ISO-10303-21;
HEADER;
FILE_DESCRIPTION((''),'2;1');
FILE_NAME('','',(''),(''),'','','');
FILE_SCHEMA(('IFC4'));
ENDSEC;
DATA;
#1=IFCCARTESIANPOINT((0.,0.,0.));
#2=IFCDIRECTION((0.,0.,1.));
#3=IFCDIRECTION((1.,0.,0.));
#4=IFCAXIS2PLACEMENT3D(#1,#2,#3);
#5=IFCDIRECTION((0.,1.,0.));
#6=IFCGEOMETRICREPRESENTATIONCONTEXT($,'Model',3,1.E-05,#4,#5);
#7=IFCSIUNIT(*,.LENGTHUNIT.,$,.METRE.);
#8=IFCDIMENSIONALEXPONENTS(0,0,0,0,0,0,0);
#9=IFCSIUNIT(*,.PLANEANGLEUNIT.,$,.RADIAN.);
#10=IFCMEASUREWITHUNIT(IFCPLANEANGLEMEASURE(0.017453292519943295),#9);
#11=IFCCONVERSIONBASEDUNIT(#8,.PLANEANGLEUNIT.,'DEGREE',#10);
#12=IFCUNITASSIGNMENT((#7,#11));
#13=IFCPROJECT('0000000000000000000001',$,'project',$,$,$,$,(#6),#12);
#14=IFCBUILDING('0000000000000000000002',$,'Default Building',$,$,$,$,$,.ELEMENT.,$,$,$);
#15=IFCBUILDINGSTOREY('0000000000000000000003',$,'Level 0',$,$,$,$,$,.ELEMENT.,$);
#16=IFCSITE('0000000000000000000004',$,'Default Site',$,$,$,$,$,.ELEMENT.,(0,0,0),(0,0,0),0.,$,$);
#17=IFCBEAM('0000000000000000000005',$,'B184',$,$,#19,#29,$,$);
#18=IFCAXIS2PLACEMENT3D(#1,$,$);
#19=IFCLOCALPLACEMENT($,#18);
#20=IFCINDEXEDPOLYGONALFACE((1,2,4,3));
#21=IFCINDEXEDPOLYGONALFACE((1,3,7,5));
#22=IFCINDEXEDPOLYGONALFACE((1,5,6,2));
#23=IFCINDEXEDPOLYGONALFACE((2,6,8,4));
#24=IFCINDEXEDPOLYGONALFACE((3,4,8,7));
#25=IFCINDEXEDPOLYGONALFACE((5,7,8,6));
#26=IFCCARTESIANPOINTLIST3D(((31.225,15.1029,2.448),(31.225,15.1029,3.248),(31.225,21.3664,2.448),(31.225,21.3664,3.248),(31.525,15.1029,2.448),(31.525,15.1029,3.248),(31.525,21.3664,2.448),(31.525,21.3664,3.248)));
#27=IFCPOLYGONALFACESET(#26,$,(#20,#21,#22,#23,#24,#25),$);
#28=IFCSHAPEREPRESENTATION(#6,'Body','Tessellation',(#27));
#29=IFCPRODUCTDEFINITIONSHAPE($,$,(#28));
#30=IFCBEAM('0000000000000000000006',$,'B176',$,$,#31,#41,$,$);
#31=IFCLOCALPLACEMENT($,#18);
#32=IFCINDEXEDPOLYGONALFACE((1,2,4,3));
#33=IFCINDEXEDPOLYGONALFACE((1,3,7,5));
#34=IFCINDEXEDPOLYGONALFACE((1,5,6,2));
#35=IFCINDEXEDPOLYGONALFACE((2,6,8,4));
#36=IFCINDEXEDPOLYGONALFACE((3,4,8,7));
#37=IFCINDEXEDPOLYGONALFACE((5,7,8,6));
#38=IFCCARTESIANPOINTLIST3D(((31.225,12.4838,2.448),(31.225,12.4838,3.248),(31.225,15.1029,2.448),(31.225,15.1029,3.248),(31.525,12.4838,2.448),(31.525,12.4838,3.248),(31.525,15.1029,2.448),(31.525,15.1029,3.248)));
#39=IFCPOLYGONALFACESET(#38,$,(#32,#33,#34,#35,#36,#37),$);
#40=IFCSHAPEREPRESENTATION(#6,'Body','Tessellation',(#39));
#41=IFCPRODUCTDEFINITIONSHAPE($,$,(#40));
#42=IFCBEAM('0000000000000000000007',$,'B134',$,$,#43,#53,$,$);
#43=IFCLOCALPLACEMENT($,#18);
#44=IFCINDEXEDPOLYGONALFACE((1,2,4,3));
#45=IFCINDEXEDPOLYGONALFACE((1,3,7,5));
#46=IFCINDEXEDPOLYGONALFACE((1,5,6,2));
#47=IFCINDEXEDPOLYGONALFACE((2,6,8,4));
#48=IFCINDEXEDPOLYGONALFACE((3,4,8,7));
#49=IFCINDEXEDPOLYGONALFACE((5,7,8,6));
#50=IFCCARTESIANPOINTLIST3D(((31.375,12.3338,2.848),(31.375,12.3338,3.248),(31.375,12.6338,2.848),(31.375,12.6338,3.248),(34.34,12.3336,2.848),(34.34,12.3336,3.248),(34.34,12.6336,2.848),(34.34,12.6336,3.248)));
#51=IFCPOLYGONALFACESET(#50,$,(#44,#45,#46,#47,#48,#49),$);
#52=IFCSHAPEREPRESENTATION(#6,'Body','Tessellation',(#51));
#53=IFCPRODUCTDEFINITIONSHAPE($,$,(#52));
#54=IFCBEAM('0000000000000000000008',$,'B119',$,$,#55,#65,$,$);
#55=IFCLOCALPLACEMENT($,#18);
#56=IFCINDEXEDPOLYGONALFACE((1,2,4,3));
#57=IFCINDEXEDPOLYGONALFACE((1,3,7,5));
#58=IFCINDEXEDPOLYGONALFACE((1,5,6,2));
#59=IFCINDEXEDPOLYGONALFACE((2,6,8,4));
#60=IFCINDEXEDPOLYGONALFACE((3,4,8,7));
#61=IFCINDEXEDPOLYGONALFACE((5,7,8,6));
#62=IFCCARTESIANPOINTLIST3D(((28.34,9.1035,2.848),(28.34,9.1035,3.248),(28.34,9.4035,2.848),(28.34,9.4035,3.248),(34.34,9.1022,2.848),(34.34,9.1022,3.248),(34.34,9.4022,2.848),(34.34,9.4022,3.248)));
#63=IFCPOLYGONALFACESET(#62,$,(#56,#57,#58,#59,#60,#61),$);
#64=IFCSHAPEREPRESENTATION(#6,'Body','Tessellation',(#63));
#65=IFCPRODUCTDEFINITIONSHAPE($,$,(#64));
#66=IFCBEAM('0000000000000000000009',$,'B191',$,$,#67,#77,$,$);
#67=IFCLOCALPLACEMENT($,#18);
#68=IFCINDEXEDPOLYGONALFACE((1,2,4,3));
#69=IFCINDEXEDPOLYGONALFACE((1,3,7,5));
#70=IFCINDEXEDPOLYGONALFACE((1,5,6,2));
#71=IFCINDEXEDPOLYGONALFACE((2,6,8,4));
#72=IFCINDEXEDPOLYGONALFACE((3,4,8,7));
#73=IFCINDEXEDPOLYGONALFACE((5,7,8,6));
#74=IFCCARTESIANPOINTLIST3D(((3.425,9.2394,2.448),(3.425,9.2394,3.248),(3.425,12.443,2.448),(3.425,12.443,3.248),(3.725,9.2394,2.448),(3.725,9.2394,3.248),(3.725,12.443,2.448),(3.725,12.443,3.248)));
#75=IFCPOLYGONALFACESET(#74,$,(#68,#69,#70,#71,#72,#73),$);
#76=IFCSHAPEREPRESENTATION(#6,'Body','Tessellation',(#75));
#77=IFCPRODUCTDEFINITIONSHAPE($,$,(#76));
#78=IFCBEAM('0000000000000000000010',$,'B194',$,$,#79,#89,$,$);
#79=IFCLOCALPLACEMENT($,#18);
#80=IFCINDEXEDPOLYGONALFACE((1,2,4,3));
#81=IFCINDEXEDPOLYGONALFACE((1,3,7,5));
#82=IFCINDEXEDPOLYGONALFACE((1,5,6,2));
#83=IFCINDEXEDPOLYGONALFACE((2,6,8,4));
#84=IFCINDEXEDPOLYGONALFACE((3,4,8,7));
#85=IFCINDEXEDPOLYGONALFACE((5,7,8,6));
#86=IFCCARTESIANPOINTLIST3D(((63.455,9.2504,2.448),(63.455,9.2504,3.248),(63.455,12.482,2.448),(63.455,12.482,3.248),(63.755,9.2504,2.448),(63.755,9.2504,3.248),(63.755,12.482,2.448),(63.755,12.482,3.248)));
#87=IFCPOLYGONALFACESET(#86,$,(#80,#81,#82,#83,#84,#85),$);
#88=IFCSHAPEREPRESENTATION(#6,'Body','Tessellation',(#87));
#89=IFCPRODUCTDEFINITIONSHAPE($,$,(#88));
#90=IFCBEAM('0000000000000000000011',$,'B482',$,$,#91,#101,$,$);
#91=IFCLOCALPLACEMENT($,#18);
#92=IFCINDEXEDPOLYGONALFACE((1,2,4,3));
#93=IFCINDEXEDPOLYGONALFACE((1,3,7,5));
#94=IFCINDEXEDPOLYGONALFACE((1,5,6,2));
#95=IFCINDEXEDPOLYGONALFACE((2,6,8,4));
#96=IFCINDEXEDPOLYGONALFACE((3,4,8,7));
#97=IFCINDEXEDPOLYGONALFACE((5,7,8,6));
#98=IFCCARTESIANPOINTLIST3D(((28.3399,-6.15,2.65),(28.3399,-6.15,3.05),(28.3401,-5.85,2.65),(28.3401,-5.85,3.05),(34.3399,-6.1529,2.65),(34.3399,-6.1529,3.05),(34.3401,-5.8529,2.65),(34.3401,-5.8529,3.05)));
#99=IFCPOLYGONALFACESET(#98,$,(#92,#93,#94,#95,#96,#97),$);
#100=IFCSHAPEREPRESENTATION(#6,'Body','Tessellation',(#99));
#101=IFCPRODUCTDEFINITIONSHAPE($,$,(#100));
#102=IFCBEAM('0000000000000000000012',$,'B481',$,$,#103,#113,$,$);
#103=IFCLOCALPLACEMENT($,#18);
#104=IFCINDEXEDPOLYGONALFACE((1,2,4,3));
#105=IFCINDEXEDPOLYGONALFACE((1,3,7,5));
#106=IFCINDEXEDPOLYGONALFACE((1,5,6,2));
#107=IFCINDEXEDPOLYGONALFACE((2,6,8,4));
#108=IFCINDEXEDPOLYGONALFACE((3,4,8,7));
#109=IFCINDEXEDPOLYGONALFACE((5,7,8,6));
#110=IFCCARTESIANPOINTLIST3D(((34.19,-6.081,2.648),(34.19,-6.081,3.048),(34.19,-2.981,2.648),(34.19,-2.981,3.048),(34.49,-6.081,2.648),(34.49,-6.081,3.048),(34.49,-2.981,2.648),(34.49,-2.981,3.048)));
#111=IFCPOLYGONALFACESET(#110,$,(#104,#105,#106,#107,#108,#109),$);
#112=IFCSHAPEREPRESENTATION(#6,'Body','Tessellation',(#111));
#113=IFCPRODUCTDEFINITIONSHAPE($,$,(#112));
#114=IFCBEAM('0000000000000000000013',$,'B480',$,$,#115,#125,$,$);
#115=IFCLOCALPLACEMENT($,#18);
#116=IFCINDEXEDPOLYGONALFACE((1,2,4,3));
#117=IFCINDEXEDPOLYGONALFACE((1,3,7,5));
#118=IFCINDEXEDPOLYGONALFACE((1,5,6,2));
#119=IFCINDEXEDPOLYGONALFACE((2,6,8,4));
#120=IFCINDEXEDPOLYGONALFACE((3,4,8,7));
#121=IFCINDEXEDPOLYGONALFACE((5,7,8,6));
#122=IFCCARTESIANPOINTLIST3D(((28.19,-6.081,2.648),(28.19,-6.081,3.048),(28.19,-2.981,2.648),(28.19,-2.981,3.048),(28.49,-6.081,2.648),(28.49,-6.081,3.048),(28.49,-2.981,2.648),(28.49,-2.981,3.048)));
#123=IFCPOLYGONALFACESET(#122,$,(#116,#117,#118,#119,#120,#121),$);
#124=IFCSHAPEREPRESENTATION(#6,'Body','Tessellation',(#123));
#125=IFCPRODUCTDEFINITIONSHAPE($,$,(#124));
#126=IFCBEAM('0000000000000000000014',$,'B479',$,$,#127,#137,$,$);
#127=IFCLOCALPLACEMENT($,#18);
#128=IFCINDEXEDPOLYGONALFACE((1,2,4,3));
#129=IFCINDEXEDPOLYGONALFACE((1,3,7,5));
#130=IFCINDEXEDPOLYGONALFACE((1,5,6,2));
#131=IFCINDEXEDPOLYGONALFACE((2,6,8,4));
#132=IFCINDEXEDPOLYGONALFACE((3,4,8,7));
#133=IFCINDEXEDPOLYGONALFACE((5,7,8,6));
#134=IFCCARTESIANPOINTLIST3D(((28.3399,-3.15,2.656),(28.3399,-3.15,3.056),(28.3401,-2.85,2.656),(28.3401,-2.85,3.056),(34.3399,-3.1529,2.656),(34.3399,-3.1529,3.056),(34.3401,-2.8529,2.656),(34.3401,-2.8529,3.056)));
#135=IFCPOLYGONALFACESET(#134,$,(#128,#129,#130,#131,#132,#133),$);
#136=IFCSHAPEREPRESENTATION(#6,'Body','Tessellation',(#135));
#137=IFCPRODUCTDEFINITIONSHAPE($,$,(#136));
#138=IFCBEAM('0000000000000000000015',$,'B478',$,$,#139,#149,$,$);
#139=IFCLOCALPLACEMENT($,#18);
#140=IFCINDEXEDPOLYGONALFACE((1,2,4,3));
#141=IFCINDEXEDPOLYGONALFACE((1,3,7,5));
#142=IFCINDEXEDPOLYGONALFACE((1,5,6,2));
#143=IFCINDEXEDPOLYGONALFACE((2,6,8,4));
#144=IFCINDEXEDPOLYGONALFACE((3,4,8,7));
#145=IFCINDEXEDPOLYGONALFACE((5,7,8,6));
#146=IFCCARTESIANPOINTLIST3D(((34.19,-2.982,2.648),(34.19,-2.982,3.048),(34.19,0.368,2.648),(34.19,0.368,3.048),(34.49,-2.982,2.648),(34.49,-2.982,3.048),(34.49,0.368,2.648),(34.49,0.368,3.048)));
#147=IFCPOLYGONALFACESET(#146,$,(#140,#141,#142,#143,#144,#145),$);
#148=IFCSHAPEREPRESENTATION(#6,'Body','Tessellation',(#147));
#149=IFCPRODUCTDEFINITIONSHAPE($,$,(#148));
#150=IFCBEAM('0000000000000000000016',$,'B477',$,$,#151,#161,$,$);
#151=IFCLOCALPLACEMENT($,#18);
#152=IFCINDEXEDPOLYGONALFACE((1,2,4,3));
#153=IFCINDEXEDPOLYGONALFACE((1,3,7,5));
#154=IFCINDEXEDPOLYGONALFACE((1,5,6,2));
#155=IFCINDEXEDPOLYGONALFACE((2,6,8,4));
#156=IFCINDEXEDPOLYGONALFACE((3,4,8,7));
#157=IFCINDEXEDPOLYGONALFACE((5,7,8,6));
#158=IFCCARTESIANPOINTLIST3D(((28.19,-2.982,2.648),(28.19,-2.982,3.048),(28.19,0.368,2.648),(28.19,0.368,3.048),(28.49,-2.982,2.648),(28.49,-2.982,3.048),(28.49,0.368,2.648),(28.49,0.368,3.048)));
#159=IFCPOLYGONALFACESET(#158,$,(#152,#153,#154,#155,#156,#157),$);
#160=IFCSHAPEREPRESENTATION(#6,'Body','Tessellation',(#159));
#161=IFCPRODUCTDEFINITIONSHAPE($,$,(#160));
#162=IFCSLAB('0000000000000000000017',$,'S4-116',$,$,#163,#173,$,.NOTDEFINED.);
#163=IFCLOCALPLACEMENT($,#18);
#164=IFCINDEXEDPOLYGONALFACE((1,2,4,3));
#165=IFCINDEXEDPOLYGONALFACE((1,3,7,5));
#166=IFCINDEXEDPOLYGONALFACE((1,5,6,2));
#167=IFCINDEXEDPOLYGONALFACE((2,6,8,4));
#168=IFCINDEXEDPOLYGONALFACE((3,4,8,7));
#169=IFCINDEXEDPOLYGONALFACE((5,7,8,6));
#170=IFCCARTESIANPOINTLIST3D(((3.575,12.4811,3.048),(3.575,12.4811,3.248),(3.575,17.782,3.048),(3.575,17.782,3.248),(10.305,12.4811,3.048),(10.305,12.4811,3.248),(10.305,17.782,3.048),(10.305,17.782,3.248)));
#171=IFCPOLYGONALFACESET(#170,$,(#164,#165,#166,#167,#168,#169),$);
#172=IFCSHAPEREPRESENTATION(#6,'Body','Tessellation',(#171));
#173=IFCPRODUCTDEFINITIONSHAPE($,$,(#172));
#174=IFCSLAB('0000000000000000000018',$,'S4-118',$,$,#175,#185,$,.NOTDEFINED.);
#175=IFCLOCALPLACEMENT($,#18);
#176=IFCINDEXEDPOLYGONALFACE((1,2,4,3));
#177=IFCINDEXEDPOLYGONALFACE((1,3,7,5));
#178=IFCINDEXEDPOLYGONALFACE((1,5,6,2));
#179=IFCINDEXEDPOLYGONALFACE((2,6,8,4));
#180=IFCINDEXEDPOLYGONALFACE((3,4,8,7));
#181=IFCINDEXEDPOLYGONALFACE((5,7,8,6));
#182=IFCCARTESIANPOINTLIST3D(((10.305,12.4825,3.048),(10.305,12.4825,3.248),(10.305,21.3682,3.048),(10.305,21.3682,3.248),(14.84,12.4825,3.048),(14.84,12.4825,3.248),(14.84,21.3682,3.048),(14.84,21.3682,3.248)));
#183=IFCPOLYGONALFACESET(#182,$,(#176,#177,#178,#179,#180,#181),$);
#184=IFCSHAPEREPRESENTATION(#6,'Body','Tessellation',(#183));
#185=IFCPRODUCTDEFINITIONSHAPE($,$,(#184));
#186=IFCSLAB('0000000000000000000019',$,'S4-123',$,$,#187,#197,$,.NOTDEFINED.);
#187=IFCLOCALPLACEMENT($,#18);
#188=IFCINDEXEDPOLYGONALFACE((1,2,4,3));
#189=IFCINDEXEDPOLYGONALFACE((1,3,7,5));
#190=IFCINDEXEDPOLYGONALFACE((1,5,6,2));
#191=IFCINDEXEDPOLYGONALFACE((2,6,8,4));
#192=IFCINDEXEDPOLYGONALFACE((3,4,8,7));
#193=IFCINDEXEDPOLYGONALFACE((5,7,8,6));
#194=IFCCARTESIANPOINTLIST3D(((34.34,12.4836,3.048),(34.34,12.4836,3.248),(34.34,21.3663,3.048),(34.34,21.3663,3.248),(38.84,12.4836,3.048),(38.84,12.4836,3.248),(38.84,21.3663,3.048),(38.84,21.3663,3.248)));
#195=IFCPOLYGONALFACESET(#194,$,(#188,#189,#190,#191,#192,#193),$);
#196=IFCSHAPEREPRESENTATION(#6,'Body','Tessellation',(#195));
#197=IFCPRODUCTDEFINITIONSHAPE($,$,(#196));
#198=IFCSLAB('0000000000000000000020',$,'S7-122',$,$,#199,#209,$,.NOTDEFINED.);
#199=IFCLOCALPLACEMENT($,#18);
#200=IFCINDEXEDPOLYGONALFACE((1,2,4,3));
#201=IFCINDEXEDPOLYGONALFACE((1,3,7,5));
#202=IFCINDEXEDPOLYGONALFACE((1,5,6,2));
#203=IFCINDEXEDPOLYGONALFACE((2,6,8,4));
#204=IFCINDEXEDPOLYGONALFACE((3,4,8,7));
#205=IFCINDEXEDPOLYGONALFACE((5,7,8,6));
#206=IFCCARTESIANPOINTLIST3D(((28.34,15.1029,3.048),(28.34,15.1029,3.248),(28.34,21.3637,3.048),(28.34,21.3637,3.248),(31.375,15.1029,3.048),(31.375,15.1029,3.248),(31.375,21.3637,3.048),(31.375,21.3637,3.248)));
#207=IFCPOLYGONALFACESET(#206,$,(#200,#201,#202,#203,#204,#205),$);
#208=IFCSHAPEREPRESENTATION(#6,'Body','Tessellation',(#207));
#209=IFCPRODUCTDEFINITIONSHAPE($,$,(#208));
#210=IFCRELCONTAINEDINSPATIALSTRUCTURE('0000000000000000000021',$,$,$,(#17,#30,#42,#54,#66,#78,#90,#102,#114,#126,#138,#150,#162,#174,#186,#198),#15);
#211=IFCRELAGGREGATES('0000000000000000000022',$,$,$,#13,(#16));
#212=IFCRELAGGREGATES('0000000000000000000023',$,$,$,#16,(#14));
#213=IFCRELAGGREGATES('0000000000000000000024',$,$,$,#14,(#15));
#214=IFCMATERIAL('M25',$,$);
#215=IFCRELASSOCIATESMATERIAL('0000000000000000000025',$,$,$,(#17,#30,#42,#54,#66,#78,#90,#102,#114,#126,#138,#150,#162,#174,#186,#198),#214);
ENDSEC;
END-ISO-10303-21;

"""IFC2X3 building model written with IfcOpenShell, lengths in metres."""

from ifc_helpers import new_model, entity, si_unit, converted_unit, direction, frame, frame_2d, origin_with_axes, place, context, project, spatial, rectangle, extrude, material, element, save


model = new_model("IFC2X3")

# Units and contexts
model_context = context("Model", 3, precision=1e-05, world=origin_with_axes(), true_north=direction((0.0, 1.0, 0.0)))
ifc_project = project(units=[si_unit("LENGTHUNIT", "METRE"), converted_unit("PLANEANGLEUNIT", "DEGREE", entity("IfcPlaneAngleMeasure", 0.017453292519943295), si_unit("PLANEANGLEUNIT", "RADIAN"), dimensions=[0, 0, 0, 0, 0, 0, 0])], contexts=[model_context])

# Site, building, storey
site = spatial("IfcSite", under=ifc_project, Name="Default Site", CompositionType="ELEMENT", RefLatitude=(0, 0, 0), RefLongitude=(0, 0, 0), RefElevation=0.0)
building = spatial("IfcBuilding", under=site, Name="Default Building", CompositionType="ELEMENT")
storey = spatial("IfcBuildingStorey", under=building, Name="Level 0", CompositionType="ELEMENT")

# Beams
ifc_material = material(Name="M25")
placement = place(None, origin_with_axes())
element("IfcBeam", 1, at=placement, inside=storey, material=ifc_material, Name="B184", context=model_context, shape_type="SweptSolid", body=[
    extrude(rectangle(XDim=0.3, YDim=0.8, at=frame_2d((0.0, 0.0), x_axis=(0.0, 1.0, 0.0))), frame((31.375, 21.3664, 2.848), z_axis=(0.0, -1.0, 0.0), x_axis=(0.0, 0.0, -1.0)), (0.0, 0.0, 1.0), 6.2635),
])
element("IfcBeam", 2, at=placement, inside=storey, material=ifc_material, Name="B176", context=model_context, shape_type="SweptSolid", body=[
    extrude(rectangle(XDim=0.3, YDim=0.8, at=frame_2d((0.0, 0.0), x_axis=(0.0, 1.0, 0.0))), frame((31.375, 15.1029, 2.848), z_axis=(0.0, -1.0, 0.0), x_axis=(0.0, 0.0, -1.0)), (0.0, 0.0, 1.0), 2.6191),
])
element("IfcBeam", 3, at=placement, inside=storey, material=ifc_material, Name="B134", context=model_context, shape_type="SweptSolid", body=[
    extrude(rectangle(XDim=0.3, YDim=0.4, at=frame_2d((0.0, 0.0), x_axis=(0.0, 1.0, 0.0))), frame((31.375, 12.4838, 3.048), z_axis=(1.0, -0.000067, 0.0), x_axis=(0.0, 0.0, -1.0)), (0.0, 0.0, 1.0), 2.965),
])
element("IfcBeam", 4, at=placement, inside=storey, material=ifc_material, Name="B119", context=model_context, shape_type="SweptSolid", body=[
    extrude(rectangle(XDim=0.3, YDim=0.4, at=frame_2d((0.0, 0.0), x_axis=(0.0, 1.0, 0.0))), frame((28.34, 9.2535, 3.048), z_axis=(1.0, -0.000213, 0.0), x_axis=(0.0, 0.0, -1.0)), (0.0, 0.0, 1.0), 6.0),
])
element("IfcBeam", 5, at=placement, inside=storey, material=ifc_material, Name="B191", context=model_context, shape_type="SweptSolid", body=[
    extrude(rectangle(XDim=0.3, YDim=0.8, at=frame_2d((0.0, 0.0), x_axis=(0.0, 1.0, 0.0))), frame((3.575, 12.443, 2.848), z_axis=(0.0, -1.0, 0.0), x_axis=(0.0, 0.0, -1.0)), (0.0, 0.0, 1.0), 3.2036),
])
element("IfcBeam", 6, at=placement, inside=storey, material=ifc_material, Name="B194", context=model_context, shape_type="SweptSolid", body=[
    extrude(rectangle(XDim=0.3, YDim=0.8, at=frame_2d((0.0, 0.0), x_axis=(0.0, 1.0, 0.0))), frame((63.605, 12.482, 2.848), z_axis=(0.0, -1.0, 0.0), x_axis=(0.0, 0.0, -1.0)), (0.0, 0.0, 1.0), 3.2316),
])
element("IfcBeam", 7, at=placement, inside=storey, material=ifc_material, Name="B482", context=model_context, shape_type="SweptSolid", body=[
    extrude(rectangle(XDim=0.3, YDim=0.4, at=frame_2d((0.0, 0.0), x_axis=(0.0, 1.0, 0.0))), frame((28.34, -6.0, 2.85), z_axis=(1.0, -0.000487, 0.0), x_axis=(0.0, 0.0, -1.0)), (0.0, 0.0, 1.0), 6.0),
])
element("IfcBeam", 8, at=placement, inside=storey, material=ifc_material, Name="B481", context=model_context, shape_type="SweptSolid", body=[
    extrude(rectangle(XDim=0.3, YDim=0.4, at=frame_2d((0.0, 0.0), x_axis=(0.0, 1.0, 0.0))), frame((34.34, -6.081, 2.848), z_axis=(0.0, 1.0, 0.0), x_axis=(0.0, 0.0, -1.0)), (0.0, 0.0, 1.0), 3.1),
])
element("IfcBeam", 9, at=placement, inside=storey, material=ifc_material, Name="B480", context=model_context, shape_type="SweptSolid", body=[
    extrude(rectangle(XDim=0.3, YDim=0.4, at=frame_2d((0.0, 0.0), x_axis=(0.0, 1.0, 0.0))), frame((28.34, -6.081, 2.848), z_axis=(0.0, 1.0, 0.0), x_axis=(0.0, 0.0, -1.0)), (0.0, 0.0, 1.0), 3.1),
])
element("IfcBeam", 10, at=placement, inside=storey, material=ifc_material, Name="B479", context=model_context, shape_type="SweptSolid", body=[
    extrude(rectangle(XDim=0.3, YDim=0.4, at=frame_2d((0.0, 0.0), x_axis=(0.0, 1.0, 0.0))), frame((28.34, -3.0, 2.856), z_axis=(1.0, -0.000487, 0.0), x_axis=(0.0, 0.0, -1.0)), (0.0, 0.0, 1.0), 6.0),
])
element("IfcBeam", 11, at=placement, inside=storey, material=ifc_material, Name="B478", context=model_context, shape_type="SweptSolid", body=[
    extrude(rectangle(XDim=0.3, YDim=0.4, at=frame_2d((0.0, 0.0), x_axis=(0.0, 1.0, 0.0))), frame((34.34, -2.982, 2.848), z_axis=(0.0, 1.0, 0.0), x_axis=(0.0, 0.0, -1.0)), (0.0, 0.0, 1.0), 3.35),
])
element("IfcBeam", 12, at=placement, inside=storey, material=ifc_material, Name="B477", context=model_context, shape_type="SweptSolid", body=[
    extrude(rectangle(XDim=0.3, YDim=0.4, at=frame_2d((0.0, 0.0), x_axis=(0.0, 1.0, 0.0))), frame((28.34, -2.982, 2.848), z_axis=(0.0, 1.0, 0.0), x_axis=(0.0, 0.0, -1.0)), (0.0, 0.0, 1.0), 3.35),
])

# Slabs
element("IfcSlab", 13, at=placement, inside=storey, material=ifc_material, Name="S4-116", PredefinedType="NOTDEFINED", context=model_context, shape_type="SweptSolid", body=[
    extrude(rectangle(XDim=6.73, YDim=5.3009, at=frame_2d((0.0, 0.0), x_axis=(1.0, 0.0, 0.0))), frame((6.94, 15.1315, 3.048), z_axis=(0.0, 0.0, 1.0), x_axis=(1.0, 0.0, 0.0)), (0.0, 0.0, 1.0), 0.2),
])
element("IfcSlab", 14, at=placement, inside=storey, material=ifc_material, Name="S4-118", PredefinedType="NOTDEFINED", context=model_context, shape_type="SweptSolid", body=[
    extrude(rectangle(XDim=4.535, YDim=8.8857, at=frame_2d((0.0, 0.0), x_axis=(1.0, 0.0, 0.0))), frame((12.5725, 16.9253, 3.048), z_axis=(0.0, 0.0, 1.0), x_axis=(1.0, 0.0, 0.0)), (0.0, 0.0, 1.0), 0.2),
])
element("IfcSlab", 15, at=placement, inside=storey, material=ifc_material, Name="S4-123", PredefinedType="NOTDEFINED", context=model_context, shape_type="SweptSolid", body=[
    extrude(rectangle(XDim=4.5, YDim=8.8827, at=frame_2d((0.0, 0.0), x_axis=(1.0, 0.0, 0.0))), frame((36.59, 16.925, 3.048), z_axis=(0.0, 0.0, 1.0), x_axis=(1.0, 0.0, 0.0)), (0.0, 0.0, 1.0), 0.2),
])
element("IfcSlab", 16, at=placement, inside=storey, material=ifc_material, Name="S7-122", PredefinedType="NOTDEFINED", context=model_context, shape_type="SweptSolid", body=[
    extrude(rectangle(XDim=3.035, YDim=6.2608, at=frame_2d((0.0, 0.0), x_axis=(1.0, 0.0, 0.0))), frame((29.8575, 18.2333, 3.048), z_axis=(0.0, 0.0, 1.0), x_axis=(1.0, 0.0, 0.0)), (0.0, 0.0, 1.0), 0.2),
])

save(model, "model.ifc")
